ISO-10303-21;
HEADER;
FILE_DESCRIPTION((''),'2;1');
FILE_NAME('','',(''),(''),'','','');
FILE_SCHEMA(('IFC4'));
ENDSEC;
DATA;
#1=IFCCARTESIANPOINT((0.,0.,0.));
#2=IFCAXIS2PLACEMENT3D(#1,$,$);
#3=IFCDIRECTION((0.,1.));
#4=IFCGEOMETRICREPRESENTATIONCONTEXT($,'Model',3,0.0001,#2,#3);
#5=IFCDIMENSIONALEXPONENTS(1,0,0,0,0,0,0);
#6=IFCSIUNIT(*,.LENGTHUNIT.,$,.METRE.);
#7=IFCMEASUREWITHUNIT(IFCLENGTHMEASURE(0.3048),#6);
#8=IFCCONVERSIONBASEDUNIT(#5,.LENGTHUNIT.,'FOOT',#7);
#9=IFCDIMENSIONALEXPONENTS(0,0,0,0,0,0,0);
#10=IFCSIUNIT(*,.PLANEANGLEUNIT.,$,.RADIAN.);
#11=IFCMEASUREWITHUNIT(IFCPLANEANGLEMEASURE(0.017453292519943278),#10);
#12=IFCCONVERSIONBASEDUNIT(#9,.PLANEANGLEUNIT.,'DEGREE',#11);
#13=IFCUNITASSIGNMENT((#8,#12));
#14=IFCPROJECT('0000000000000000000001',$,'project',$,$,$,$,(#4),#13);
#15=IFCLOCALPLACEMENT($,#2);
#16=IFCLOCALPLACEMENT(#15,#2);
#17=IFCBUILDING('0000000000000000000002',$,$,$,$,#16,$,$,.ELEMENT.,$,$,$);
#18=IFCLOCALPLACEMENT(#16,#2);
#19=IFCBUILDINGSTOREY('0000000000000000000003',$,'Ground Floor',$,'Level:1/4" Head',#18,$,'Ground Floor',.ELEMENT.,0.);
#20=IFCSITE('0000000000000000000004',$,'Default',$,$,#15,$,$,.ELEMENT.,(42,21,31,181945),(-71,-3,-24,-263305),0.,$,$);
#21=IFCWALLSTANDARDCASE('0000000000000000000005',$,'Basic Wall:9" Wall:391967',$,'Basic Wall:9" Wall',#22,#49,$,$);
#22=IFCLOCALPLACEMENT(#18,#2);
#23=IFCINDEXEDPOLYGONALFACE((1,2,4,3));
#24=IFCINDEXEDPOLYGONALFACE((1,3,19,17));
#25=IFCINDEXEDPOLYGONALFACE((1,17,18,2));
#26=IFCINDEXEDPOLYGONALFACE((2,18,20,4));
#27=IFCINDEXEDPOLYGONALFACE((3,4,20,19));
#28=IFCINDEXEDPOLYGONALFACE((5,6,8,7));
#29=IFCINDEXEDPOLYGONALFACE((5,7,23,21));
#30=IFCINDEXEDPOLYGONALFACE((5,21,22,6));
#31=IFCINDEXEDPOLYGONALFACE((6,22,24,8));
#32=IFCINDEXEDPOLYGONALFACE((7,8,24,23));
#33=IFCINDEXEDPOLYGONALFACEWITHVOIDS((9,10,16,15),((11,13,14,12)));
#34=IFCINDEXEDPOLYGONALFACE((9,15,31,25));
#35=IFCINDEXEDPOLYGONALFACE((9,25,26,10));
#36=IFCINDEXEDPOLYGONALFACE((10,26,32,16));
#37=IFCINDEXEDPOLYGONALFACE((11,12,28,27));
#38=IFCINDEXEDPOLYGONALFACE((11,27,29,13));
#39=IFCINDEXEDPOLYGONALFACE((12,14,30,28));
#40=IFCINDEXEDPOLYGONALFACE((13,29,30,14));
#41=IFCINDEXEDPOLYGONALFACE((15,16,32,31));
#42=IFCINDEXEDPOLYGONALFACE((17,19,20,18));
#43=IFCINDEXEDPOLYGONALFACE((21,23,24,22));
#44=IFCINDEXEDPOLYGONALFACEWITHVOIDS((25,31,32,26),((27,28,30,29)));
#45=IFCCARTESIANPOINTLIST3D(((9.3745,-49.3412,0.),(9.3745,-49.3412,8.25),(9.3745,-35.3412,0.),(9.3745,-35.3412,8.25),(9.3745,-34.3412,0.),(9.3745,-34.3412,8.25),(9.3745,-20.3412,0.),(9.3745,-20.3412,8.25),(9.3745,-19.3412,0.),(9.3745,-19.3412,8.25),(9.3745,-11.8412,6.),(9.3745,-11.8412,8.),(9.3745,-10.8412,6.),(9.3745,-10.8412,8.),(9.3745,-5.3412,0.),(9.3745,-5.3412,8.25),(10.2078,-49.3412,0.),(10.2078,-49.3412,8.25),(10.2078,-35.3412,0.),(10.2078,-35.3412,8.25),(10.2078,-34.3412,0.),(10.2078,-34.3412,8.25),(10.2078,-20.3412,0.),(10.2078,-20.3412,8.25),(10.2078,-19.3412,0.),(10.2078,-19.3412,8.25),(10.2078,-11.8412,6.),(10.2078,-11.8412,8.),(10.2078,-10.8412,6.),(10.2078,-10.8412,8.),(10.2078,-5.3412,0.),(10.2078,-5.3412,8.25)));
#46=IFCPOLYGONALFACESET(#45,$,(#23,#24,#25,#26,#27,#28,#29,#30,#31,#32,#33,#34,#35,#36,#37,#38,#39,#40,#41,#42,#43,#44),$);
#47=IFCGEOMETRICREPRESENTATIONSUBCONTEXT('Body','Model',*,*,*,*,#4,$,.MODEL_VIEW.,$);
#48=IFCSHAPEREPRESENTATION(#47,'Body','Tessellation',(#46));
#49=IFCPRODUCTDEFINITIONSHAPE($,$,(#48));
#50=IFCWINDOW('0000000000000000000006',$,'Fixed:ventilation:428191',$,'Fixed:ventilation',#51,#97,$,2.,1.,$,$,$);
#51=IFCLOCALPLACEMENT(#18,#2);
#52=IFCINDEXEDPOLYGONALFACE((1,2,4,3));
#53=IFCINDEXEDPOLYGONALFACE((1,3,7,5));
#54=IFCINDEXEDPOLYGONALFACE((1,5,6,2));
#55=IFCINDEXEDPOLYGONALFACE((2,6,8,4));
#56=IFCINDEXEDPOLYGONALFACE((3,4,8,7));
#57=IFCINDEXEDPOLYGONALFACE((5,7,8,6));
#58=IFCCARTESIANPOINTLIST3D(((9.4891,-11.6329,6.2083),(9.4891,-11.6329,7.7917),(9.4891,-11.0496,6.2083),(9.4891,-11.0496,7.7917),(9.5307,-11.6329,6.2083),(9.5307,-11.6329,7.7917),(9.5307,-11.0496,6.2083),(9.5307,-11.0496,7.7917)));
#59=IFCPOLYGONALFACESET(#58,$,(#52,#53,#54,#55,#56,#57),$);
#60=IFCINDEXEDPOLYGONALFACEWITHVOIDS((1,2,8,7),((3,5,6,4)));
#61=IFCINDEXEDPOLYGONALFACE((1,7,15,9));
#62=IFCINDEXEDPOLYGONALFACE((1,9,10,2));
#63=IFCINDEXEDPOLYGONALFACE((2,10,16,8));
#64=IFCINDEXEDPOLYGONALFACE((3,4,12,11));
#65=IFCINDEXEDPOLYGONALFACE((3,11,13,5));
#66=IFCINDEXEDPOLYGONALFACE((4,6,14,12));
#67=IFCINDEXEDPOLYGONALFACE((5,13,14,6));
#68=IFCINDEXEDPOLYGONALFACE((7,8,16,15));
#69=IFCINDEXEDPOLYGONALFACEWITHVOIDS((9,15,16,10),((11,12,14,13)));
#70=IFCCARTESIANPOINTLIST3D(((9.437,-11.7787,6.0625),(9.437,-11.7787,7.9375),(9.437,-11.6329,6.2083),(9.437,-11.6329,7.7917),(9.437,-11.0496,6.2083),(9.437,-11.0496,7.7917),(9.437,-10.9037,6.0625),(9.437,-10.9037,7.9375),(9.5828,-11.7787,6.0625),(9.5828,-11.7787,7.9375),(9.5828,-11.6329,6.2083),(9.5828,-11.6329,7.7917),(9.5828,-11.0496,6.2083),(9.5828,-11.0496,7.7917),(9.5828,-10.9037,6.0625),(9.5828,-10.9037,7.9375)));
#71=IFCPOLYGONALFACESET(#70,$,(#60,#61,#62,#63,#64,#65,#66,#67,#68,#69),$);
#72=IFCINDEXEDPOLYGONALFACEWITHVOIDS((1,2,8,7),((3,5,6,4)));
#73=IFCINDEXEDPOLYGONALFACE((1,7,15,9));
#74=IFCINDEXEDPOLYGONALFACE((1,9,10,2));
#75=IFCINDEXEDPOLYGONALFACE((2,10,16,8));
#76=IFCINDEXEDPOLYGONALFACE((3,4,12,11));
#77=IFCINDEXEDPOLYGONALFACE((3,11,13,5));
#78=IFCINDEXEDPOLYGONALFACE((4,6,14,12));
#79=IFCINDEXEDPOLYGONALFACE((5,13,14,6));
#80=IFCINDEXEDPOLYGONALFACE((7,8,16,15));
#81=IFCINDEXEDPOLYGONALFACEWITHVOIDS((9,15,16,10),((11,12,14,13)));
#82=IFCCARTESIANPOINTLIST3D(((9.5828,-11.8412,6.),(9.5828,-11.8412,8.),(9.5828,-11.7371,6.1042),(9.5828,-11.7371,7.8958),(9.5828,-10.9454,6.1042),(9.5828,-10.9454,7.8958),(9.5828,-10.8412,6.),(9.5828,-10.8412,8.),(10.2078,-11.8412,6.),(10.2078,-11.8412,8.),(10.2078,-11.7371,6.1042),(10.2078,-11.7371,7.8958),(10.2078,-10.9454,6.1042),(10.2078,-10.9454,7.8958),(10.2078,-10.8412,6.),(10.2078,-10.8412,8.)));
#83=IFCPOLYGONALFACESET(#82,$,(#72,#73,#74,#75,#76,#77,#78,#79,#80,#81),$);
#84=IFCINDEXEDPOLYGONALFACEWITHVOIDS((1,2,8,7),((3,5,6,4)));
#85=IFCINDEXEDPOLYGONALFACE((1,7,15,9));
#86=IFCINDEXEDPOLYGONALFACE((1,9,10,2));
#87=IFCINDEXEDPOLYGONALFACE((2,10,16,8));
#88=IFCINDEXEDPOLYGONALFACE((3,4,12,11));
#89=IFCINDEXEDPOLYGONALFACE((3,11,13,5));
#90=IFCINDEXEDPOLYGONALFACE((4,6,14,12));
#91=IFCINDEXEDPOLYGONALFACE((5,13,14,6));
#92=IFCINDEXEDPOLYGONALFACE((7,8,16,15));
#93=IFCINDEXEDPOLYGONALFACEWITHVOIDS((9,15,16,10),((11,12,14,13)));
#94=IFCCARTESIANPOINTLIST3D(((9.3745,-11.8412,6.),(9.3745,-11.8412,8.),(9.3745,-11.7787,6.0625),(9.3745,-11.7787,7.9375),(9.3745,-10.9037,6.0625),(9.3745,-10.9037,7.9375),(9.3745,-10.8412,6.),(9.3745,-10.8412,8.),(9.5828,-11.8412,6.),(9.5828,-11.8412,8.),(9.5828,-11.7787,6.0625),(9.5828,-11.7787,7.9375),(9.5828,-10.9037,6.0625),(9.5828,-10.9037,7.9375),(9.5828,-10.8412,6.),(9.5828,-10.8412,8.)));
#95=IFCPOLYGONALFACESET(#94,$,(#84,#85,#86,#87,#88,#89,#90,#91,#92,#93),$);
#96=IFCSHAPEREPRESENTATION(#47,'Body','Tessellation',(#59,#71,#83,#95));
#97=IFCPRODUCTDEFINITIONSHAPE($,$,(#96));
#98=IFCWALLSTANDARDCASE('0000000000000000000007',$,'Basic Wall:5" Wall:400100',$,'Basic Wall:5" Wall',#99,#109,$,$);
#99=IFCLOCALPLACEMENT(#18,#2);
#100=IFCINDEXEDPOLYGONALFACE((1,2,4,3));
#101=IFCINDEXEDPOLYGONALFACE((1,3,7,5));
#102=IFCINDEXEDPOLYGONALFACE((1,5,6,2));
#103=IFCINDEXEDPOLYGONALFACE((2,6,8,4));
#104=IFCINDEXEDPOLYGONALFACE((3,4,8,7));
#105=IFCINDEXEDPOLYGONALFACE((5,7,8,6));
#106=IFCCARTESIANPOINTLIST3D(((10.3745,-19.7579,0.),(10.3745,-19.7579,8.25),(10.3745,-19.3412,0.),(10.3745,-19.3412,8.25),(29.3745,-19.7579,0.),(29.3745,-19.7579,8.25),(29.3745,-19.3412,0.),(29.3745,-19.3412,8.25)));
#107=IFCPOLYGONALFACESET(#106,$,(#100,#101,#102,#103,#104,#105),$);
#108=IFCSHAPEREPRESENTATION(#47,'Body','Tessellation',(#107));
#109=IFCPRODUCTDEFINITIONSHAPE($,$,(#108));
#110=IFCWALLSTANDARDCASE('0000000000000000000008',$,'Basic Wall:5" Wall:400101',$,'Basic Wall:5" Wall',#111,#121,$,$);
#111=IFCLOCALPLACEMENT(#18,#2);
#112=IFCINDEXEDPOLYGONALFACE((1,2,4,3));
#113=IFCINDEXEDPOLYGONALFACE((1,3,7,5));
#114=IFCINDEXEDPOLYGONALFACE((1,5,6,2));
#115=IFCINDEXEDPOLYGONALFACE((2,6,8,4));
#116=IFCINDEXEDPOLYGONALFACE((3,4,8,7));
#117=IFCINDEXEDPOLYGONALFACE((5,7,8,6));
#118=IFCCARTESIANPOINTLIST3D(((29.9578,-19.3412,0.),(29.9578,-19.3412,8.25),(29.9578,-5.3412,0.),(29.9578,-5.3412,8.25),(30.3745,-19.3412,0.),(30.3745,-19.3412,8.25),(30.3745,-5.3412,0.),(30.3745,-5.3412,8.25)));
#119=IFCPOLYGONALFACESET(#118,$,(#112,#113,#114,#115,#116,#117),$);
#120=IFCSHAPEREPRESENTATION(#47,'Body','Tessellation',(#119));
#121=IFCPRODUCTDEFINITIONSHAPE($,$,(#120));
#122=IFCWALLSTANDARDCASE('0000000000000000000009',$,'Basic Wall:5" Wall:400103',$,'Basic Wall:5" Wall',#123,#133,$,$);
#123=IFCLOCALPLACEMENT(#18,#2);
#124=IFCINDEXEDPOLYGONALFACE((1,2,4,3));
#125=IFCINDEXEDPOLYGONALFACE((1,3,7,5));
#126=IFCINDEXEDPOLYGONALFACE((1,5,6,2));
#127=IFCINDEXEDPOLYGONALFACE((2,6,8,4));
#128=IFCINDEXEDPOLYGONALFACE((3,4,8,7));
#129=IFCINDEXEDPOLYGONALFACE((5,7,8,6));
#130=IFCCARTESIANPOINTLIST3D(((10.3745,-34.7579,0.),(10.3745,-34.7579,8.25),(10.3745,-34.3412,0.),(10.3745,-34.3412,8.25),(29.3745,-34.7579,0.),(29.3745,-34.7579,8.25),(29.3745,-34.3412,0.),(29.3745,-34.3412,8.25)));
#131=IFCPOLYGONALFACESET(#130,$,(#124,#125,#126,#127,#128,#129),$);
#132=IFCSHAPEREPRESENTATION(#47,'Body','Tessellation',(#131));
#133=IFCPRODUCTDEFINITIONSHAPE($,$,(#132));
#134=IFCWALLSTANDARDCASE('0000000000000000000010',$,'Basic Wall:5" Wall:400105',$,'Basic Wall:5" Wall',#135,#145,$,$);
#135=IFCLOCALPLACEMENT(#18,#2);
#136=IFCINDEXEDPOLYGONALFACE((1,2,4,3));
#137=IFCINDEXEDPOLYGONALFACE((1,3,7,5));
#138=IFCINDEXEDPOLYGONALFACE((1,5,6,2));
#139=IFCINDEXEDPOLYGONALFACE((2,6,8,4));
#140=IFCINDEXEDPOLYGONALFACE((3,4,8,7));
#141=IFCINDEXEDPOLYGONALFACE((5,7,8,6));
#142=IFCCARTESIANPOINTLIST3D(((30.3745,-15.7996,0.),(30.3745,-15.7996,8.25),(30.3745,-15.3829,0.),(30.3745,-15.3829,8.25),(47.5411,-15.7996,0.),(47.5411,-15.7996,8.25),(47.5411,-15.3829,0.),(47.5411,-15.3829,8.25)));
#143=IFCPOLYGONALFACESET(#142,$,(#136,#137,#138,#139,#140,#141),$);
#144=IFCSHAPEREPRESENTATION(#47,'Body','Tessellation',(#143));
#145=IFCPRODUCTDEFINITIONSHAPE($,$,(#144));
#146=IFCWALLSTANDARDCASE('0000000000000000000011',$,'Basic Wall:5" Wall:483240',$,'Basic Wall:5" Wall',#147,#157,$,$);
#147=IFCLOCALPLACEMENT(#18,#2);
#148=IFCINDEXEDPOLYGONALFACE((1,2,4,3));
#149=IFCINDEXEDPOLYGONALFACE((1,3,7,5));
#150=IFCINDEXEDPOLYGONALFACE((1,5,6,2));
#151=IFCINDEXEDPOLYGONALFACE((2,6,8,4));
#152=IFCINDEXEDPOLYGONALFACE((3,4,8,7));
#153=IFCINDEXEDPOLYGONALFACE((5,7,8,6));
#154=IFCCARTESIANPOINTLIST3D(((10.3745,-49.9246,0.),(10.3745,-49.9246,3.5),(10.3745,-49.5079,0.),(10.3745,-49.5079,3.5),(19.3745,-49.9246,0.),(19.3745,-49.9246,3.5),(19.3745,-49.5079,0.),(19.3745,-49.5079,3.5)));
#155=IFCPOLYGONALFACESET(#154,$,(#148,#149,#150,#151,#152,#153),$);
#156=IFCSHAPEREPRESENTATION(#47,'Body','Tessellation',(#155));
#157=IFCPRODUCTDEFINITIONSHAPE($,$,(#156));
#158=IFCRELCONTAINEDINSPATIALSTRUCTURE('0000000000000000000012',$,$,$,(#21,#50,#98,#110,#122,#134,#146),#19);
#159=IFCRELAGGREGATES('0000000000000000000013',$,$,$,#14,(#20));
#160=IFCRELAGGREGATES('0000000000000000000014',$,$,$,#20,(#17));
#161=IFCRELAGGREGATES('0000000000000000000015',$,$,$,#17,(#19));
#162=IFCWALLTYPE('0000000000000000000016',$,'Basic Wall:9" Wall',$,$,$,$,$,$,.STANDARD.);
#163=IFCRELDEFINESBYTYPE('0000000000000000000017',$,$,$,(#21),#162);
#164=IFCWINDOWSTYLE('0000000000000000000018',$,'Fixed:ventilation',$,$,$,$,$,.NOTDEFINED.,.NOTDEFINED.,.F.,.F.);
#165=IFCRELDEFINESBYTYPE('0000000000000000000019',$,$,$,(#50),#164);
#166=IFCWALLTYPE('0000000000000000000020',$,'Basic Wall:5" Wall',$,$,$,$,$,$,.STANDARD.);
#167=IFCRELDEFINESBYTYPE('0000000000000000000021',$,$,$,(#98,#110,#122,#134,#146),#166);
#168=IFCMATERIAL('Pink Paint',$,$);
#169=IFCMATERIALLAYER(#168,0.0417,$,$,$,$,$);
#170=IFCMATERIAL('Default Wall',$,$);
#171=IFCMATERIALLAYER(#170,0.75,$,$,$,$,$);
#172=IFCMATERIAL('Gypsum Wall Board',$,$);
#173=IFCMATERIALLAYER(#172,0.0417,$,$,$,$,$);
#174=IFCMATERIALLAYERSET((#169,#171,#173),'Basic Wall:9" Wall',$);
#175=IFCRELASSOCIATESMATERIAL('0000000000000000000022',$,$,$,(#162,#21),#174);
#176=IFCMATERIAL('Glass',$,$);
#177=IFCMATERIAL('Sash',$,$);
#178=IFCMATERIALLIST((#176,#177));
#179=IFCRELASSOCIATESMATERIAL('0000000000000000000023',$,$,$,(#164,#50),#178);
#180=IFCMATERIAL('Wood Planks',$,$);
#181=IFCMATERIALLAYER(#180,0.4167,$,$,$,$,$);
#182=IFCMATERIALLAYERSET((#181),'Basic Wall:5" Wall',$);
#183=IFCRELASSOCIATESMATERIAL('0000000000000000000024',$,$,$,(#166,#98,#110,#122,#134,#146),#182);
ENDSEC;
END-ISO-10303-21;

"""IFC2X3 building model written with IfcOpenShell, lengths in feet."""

from ifc_helpers import new_model, entity, si_unit, converted_unit, direction, frame, frame_2d, origin, origin_2d_with_axis, place, context, subcontext, project, spatial, polyline, rectangle, outline, extrude, clip, bounded_halfspace, source, transform, mapped, material, material_list, layer, layer_set, layer_usage, type_object, type_shapes, element, fill, save


model = new_model("IFC2X3")

# Units and contexts
model_context = context("Model", 3, precision=0.0001, world=origin(), true_north=direction((0.0, 1.0)))
body_context = subcontext(model_context, "Body", "Model", "MODEL_VIEW")
ifc_project = project(units=[converted_unit("LENGTHUNIT", "FOOT", entity("IfcLengthMeasure", 0.3048), si_unit("LENGTHUNIT", "METRE"), dimensions=[1, 0, 0, 0, 0, 0, 0]), converted_unit("PLANEANGLEUNIT", "DEGREE", entity("IfcPlaneAngleMeasure", 0.017453292519943278), si_unit("PLANEANGLEUNIT", "RADIAN"), dimensions=[0, 0, 0, 0, 0, 0, 0])], contexts=[model_context])

# Site, building, storey
site_placement = place(None, origin())
site = spatial("IfcSite", under=ifc_project, at=site_placement, Name="Default", CompositionType="ELEMENT", RefLatitude=(42, 21, 31, 181945), RefLongitude=(-71, -3, -24, -263305), RefElevation=0.0)
building_placement = place(site_placement, origin())
building = spatial("IfcBuilding", under=site, at=building_placement, CompositionType="ELEMENT")
storey_placement = place(building_placement, origin())
storey = spatial("IfcBuildingStorey", under=building, at=storey_placement, Name="Ground Floor", ObjectType="Level:1/4\" Head", LongName="Ground Floor", CompositionType="ELEMENT", Elevation=0.0)

# Wall, openings, window
ifc_material_1 = material(Name="Pink Paint")
ifc_layer_1 = layer(ifc_material_1, 0.0417)
ifc_material_2 = material(Name="Default Wall")
ifc_layer_2 = layer(ifc_material_2, 0.75)
ifc_material_3 = material(Name="Gypsum Wall Board")
ifc_layer_3 = layer(ifc_material_3, 0.0417)
ifc_layer_set_1 = layer_set([ifc_layer_1, ifc_layer_2, ifc_layer_3], Name="Basic Wall:9\" Wall")
ifc_layer_usage_1 = layer_usage(ifc_layer_set_1, "AXIS2", "NEGATIVE", 0.4167)
wall_type_1 = type_object("IfcWallType", Name="Basic Wall:9\" Wall", PredefinedType="STANDARD", material=ifc_layer_set_1)
wall_1_placement = place(storey_placement, frame((9.7911, -49.3412, 0.0), z_axis=(0.0, 0.0, 1.0), x_axis=(0.0, 1.0, 0.0)))
wall_1 = element("IfcWallStandardCase", 1, at=wall_1_placement, inside=storey, type_object=wall_type_1, material=ifc_layer_usage_1, Name="Basic Wall:9\" Wall:391967", ObjectType="Basic Wall:9\" Wall", context=body_context, shape_type="Clipping", body=[
    clip(clip(clip(clip(clip(extrude(rectangle(XDim=44.0, YDim=0.8333, at=frame_2d((22.0, 0.0), x_axis=(-1.0, 0.0))), origin(), (0.0, 0.0, 1.0), 8.25), bounded_halfspace(frame((0.0, 0.4167, 0.0), z_axis=(1.0, 0.0, 0.0), x_axis=(0.0, 0.0, -1.0)), True, frame((0.0, 0.4167, 0.0), z_axis=(1.0, 0.0, 0.0), x_axis=(0.0, 0.0, -1.0)), polyline([(0.0, 0.0), (-8.25, 0.0), (-8.25, -0.8333), (0.0, -0.8333), (0.0, 0.0)]))), bounded_halfspace(frame((44.0, -0.4167, 0.0), z_axis=(-1.0, 0.0, 0.0), x_axis=(0.0, 0.0, -1.0)), True, frame((44.0, -0.4167, 0.0), z_axis=(-1.0, 0.0, 0.0), x_axis=(0.0, 0.0, -1.0)), polyline([(0.0, 0.0), (-8.25, 0.0), (-8.25, -0.8333), (0.0, -0.8333), (0.0, 0.0)]))), bounded_halfspace(frame((30.0, -0.4167, 8.25), z_axis=(0.0, 0.0, 1.0), x_axis=(0.0, -1.0, 0.0)), False, frame((30.0, -0.4167, 8.25), z_axis=(0.0, 0.0, 1.0), x_axis=(0.0, -1.0, 0.0)), polyline([(0.0, 0.0), (0.0, 14.0), (-0.8333, 14.0), (-0.8333, 0.0), (0.0, 0.0)]))), bounded_halfspace(frame((15.0, -0.4167, 8.25), z_axis=(0.0, 0.0, 1.0), x_axis=(0.0, -1.0, 0.0)), False, frame((15.0, -0.4167, 8.25), z_axis=(0.0, 0.0, 1.0), x_axis=(0.0, -1.0, 0.0)), polyline([(0.0, 0.0), (0.0, 14.0), (-0.8333, 14.0), (-0.8333, 0.0), (0.0, 0.0)]))), bounded_halfspace(frame((0.0, -0.4167, 8.25), z_axis=(0.0, 0.0, 1.0), x_axis=(0.0, -1.0, 0.0)), False, frame((0.0, -0.4167, 8.25), z_axis=(0.0, 0.0, 1.0), x_axis=(0.0, -1.0, 0.0)), polyline([(0.0, 0.0), (0.0, 14.0), (-0.8333, 14.0), (-0.8333, 0.0), (0.0, 0.0)]))),
])
opening_1_placement = place(storey_placement, frame((9.7911, -49.3412, 0.0), z_axis=(0.0, 0.0, 1.0), x_axis=(0.0, 1.0, 0.0)))
element("IfcOpeningElement", 2, at=opening_1_placement, cuts=wall_1, ObjectType="Opening", context=body_context, shape_type="SweptSolid", body=[
    extrude(rectangle(XDim=8.25, YDim=0.8333, at=frame_2d((0.0, 0.0), x_axis=(0.0, 1.0))), frame((29.0, 0.0, 4.125), z_axis=(1.0, 0.0, 0.0), x_axis=(0.0, 1.0, 0.0)), (0.0, 0.0, 1.0), 1.0),
])
opening_2_placement = place(storey_placement, frame((9.7911, -49.3412, 0.0), z_axis=(0.0, 0.0, 1.0), x_axis=(0.0, 1.0, 0.0)))
element("IfcOpeningElement", 3, at=opening_2_placement, cuts=wall_1, ObjectType="Opening", context=body_context, shape_type="SweptSolid", body=[
    extrude(rectangle(XDim=8.25, YDim=0.8333, at=frame_2d((0.0, 0.0), x_axis=(0.0, 1.0))), frame((14.0, 0.0, 4.125), z_axis=(1.0, 0.0, 0.0), x_axis=(0.0, 1.0, 0.0)), (0.0, 0.0, 1.0), 1.0),
])
opening_3_placement = place(wall_1_placement, frame((37.5, -0.4167, 6.0)))
opening_3 = element("IfcOpeningElement", 4, at=opening_3_placement, cuts=wall_1, ObjectType="Opening", context=body_context, shape_type="SweptSolid", body=[
    extrude(rectangle(XDim=2.0, YDim=1.0, at=frame_2d((1.0, 0.5), x_axis=(-1.0, 0.0))), frame((0.0, 0.0, 0.0), z_axis=(0.0, 1.0, 0.0), x_axis=(0.0, 0.0, 1.0)), (0.0, 0.0, 1.0), 0.8333),
])
ifc_material_4 = material(Name="Glass")
ifc_material_5 = material(Name="Sash")
ifc_material_list_1 = material_list([ifc_material_4, ifc_material_5])
window_style = type_object("IfcWindowStyle", Name="Fixed:ventilation", ConstructionType="NOTDEFINED", OperationType="NOTDEFINED", ParameterTakesPrecedence=False, Sizeable=False, material=ifc_material_list_1)
shared_shape_1 = source(origin(), body_context, "Body", "SweptSolid", [
    extrude(rectangle(XDim=0.0417, YDim=0.5833, at=origin_2d_with_axis()), frame((0.5, 0.6979, 0.2083), z_axis=(0.0, 0.0, 1.0), x_axis=(0.0, 1.0, 0.0)), (0.0, 0.0, 1.0), 1.5833),
    extrude(outline(polyline([(-0.4375, -0.9375), (0.4375, -0.9375), (0.4375, 0.9375), (-0.4375, 0.9375), (-0.4375, -0.9375)]), holes=[polyline([(-0.2917, -0.7917), (-0.2917, 0.7917), (0.2917, 0.7917), (0.2917, -0.7917), (-0.2917, -0.7917)])]), frame((0.5, 0.625, 1.0), z_axis=(0.0, 1.0, 0.0), x_axis=(1.0, 0.0, 0.0)), (0.0, 0.0, 1.0), 0.1458),
    extrude(outline(polyline([(-0.5, -1.0), (0.5, -1.0), (0.5, 1.0), (-0.5, 1.0), (-0.5, -1.0)]), holes=[polyline([(-0.3958, -0.8958), (-0.3958, 0.8958), (0.3958, 0.8958), (0.3958, -0.8958), (-0.3958, -0.8958)])]), frame((0.5, 0.0, 1.0), z_axis=(0.0, 1.0, 0.0), x_axis=(1.0, 0.0, 0.0)), (0.0, 0.0, 1.0), 0.625),
    extrude(outline(polyline([(-1.0, -0.5), (1.0, -0.5), (1.0, 0.5), (-1.0, 0.5), (-1.0, -0.5)]), holes=[polyline([(-0.9375, -0.4375), (-0.9375, 0.4375), (0.9375, 0.4375), (0.9375, -0.4375), (-0.9375, -0.4375)])]), frame((0.5, 0.625, 1.0), z_axis=(0.0, 1.0, 0.0), x_axis=(0.0, 0.0, -1.0)), (0.0, 0.0, 1.0), 0.2083),
])
type_shapes(window_style, [shared_shape_1])
window_placement = place(opening_3_placement, origin())
window = element("IfcWindow", 5, at=window_placement, inside=storey, type_object=window_style, material=ifc_material_list_1, Name="Fixed:ventilation:428191", ObjectType="Fixed:ventilation", OverallHeight=2.0, OverallWidth=1.0, context=body_context, shape_type="MappedRepresentation", body=[
    mapped(shared_shape_1, transform((0.0, 0.0, 0.0), scale=1.0)),
])
fill(opening_3, window)

# Walls
ifc_material_6 = material(Name="Wood Planks")
ifc_layer_4 = layer(ifc_material_6, 0.4167)
ifc_layer_set_2 = layer_set([ifc_layer_4], Name="Basic Wall:5\" Wall")
ifc_layer_usage_2 = layer_usage(ifc_layer_set_2, "AXIS2", "NEGATIVE", 0.2083)
wall_type_2 = type_object("IfcWallType", Name="Basic Wall:5\" Wall", PredefinedType="STANDARD", material=ifc_layer_set_2)
wall_2_placement = place(storey_placement, frame((10.3745, -19.5496, 0.0)))
element("IfcWallStandardCase", 6, at=wall_2_placement, inside=storey, type_object=wall_type_2, material=ifc_layer_usage_2, Name="Basic Wall:5\" Wall:400100", ObjectType="Basic Wall:5\" Wall", context=body_context, shape_type="SweptSolid", body=[
    extrude(rectangle(XDim=19.0, YDim=0.4167, at=frame_2d((9.5, 0.0), x_axis=(-1.0, 0.0))), origin(), (0.0, 0.0, 1.0), 8.25),
])
wall_3_placement = place(storey_placement, frame((30.1661, -19.3412, 0.0), z_axis=(0.0, 0.0, 1.0), x_axis=(0.0, 1.0, 0.0)))
element("IfcWallStandardCase", 7, at=wall_3_placement, inside=storey, type_object=wall_type_2, material=ifc_layer_usage_2, Name="Basic Wall:5\" Wall:400101", ObjectType="Basic Wall:5\" Wall", context=body_context, shape_type="SweptSolid", body=[
    extrude(rectangle(XDim=14.0, YDim=0.4167, at=frame_2d((7.0, 0.0), x_axis=(-1.0, 0.0))), origin(), (0.0, 0.0, 1.0), 8.25),
])

# Wall
wall_4_placement = place(storey_placement, frame((29.3745, -34.5496, 0.0), z_axis=(0.0, 0.0, 1.0), x_axis=(-1.0, 0.0, 0.0)))
element("IfcWallStandardCase", 8, at=wall_4_placement, inside=storey, type_object=wall_type_2, material=ifc_layer_usage_2, Name="Basic Wall:5\" Wall:400103", ObjectType="Basic Wall:5\" Wall", context=body_context, shape_type="SweptSolid", body=[
    extrude(rectangle(XDim=19.0, YDim=0.4167, at=frame_2d((9.5, 0.0), x_axis=(-1.0, 0.0))), origin(), (0.0, 0.0, 1.0), 8.25),
])

# Walls
wall_5_placement = place(storey_placement, frame((30.3745, -15.5912, 0.0)))
element("IfcWallStandardCase", 9, at=wall_5_placement, inside=storey, type_object=wall_type_2, material=ifc_layer_usage_2, Name="Basic Wall:5\" Wall:400105", ObjectType="Basic Wall:5\" Wall", context=body_context, shape_type="SweptSolid", body=[
    extrude(rectangle(XDim=17.1667, YDim=0.4167, at=frame_2d((8.5833, 0.0), x_axis=(-1.0, 0.0))), origin(), (0.0, 0.0, 1.0), 8.25),
])
wall_6_placement = place(storey_placement, frame((10.3745, -49.7162, 0.0)))
element("IfcWallStandardCase", 10, at=wall_6_placement, inside=storey, type_object=wall_type_2, material=ifc_layer_usage_2, Name="Basic Wall:5\" Wall:483240", ObjectType="Basic Wall:5\" Wall", context=body_context, shape_type="SweptSolid", body=[
    extrude(rectangle(XDim=9.0, YDim=0.4167, at=frame_2d((4.5, 0.0), x_axis=(-1.0, 0.0))), origin(), (0.0, 0.0, 1.0), 3.5),
])

save(model, "model.ifc")
